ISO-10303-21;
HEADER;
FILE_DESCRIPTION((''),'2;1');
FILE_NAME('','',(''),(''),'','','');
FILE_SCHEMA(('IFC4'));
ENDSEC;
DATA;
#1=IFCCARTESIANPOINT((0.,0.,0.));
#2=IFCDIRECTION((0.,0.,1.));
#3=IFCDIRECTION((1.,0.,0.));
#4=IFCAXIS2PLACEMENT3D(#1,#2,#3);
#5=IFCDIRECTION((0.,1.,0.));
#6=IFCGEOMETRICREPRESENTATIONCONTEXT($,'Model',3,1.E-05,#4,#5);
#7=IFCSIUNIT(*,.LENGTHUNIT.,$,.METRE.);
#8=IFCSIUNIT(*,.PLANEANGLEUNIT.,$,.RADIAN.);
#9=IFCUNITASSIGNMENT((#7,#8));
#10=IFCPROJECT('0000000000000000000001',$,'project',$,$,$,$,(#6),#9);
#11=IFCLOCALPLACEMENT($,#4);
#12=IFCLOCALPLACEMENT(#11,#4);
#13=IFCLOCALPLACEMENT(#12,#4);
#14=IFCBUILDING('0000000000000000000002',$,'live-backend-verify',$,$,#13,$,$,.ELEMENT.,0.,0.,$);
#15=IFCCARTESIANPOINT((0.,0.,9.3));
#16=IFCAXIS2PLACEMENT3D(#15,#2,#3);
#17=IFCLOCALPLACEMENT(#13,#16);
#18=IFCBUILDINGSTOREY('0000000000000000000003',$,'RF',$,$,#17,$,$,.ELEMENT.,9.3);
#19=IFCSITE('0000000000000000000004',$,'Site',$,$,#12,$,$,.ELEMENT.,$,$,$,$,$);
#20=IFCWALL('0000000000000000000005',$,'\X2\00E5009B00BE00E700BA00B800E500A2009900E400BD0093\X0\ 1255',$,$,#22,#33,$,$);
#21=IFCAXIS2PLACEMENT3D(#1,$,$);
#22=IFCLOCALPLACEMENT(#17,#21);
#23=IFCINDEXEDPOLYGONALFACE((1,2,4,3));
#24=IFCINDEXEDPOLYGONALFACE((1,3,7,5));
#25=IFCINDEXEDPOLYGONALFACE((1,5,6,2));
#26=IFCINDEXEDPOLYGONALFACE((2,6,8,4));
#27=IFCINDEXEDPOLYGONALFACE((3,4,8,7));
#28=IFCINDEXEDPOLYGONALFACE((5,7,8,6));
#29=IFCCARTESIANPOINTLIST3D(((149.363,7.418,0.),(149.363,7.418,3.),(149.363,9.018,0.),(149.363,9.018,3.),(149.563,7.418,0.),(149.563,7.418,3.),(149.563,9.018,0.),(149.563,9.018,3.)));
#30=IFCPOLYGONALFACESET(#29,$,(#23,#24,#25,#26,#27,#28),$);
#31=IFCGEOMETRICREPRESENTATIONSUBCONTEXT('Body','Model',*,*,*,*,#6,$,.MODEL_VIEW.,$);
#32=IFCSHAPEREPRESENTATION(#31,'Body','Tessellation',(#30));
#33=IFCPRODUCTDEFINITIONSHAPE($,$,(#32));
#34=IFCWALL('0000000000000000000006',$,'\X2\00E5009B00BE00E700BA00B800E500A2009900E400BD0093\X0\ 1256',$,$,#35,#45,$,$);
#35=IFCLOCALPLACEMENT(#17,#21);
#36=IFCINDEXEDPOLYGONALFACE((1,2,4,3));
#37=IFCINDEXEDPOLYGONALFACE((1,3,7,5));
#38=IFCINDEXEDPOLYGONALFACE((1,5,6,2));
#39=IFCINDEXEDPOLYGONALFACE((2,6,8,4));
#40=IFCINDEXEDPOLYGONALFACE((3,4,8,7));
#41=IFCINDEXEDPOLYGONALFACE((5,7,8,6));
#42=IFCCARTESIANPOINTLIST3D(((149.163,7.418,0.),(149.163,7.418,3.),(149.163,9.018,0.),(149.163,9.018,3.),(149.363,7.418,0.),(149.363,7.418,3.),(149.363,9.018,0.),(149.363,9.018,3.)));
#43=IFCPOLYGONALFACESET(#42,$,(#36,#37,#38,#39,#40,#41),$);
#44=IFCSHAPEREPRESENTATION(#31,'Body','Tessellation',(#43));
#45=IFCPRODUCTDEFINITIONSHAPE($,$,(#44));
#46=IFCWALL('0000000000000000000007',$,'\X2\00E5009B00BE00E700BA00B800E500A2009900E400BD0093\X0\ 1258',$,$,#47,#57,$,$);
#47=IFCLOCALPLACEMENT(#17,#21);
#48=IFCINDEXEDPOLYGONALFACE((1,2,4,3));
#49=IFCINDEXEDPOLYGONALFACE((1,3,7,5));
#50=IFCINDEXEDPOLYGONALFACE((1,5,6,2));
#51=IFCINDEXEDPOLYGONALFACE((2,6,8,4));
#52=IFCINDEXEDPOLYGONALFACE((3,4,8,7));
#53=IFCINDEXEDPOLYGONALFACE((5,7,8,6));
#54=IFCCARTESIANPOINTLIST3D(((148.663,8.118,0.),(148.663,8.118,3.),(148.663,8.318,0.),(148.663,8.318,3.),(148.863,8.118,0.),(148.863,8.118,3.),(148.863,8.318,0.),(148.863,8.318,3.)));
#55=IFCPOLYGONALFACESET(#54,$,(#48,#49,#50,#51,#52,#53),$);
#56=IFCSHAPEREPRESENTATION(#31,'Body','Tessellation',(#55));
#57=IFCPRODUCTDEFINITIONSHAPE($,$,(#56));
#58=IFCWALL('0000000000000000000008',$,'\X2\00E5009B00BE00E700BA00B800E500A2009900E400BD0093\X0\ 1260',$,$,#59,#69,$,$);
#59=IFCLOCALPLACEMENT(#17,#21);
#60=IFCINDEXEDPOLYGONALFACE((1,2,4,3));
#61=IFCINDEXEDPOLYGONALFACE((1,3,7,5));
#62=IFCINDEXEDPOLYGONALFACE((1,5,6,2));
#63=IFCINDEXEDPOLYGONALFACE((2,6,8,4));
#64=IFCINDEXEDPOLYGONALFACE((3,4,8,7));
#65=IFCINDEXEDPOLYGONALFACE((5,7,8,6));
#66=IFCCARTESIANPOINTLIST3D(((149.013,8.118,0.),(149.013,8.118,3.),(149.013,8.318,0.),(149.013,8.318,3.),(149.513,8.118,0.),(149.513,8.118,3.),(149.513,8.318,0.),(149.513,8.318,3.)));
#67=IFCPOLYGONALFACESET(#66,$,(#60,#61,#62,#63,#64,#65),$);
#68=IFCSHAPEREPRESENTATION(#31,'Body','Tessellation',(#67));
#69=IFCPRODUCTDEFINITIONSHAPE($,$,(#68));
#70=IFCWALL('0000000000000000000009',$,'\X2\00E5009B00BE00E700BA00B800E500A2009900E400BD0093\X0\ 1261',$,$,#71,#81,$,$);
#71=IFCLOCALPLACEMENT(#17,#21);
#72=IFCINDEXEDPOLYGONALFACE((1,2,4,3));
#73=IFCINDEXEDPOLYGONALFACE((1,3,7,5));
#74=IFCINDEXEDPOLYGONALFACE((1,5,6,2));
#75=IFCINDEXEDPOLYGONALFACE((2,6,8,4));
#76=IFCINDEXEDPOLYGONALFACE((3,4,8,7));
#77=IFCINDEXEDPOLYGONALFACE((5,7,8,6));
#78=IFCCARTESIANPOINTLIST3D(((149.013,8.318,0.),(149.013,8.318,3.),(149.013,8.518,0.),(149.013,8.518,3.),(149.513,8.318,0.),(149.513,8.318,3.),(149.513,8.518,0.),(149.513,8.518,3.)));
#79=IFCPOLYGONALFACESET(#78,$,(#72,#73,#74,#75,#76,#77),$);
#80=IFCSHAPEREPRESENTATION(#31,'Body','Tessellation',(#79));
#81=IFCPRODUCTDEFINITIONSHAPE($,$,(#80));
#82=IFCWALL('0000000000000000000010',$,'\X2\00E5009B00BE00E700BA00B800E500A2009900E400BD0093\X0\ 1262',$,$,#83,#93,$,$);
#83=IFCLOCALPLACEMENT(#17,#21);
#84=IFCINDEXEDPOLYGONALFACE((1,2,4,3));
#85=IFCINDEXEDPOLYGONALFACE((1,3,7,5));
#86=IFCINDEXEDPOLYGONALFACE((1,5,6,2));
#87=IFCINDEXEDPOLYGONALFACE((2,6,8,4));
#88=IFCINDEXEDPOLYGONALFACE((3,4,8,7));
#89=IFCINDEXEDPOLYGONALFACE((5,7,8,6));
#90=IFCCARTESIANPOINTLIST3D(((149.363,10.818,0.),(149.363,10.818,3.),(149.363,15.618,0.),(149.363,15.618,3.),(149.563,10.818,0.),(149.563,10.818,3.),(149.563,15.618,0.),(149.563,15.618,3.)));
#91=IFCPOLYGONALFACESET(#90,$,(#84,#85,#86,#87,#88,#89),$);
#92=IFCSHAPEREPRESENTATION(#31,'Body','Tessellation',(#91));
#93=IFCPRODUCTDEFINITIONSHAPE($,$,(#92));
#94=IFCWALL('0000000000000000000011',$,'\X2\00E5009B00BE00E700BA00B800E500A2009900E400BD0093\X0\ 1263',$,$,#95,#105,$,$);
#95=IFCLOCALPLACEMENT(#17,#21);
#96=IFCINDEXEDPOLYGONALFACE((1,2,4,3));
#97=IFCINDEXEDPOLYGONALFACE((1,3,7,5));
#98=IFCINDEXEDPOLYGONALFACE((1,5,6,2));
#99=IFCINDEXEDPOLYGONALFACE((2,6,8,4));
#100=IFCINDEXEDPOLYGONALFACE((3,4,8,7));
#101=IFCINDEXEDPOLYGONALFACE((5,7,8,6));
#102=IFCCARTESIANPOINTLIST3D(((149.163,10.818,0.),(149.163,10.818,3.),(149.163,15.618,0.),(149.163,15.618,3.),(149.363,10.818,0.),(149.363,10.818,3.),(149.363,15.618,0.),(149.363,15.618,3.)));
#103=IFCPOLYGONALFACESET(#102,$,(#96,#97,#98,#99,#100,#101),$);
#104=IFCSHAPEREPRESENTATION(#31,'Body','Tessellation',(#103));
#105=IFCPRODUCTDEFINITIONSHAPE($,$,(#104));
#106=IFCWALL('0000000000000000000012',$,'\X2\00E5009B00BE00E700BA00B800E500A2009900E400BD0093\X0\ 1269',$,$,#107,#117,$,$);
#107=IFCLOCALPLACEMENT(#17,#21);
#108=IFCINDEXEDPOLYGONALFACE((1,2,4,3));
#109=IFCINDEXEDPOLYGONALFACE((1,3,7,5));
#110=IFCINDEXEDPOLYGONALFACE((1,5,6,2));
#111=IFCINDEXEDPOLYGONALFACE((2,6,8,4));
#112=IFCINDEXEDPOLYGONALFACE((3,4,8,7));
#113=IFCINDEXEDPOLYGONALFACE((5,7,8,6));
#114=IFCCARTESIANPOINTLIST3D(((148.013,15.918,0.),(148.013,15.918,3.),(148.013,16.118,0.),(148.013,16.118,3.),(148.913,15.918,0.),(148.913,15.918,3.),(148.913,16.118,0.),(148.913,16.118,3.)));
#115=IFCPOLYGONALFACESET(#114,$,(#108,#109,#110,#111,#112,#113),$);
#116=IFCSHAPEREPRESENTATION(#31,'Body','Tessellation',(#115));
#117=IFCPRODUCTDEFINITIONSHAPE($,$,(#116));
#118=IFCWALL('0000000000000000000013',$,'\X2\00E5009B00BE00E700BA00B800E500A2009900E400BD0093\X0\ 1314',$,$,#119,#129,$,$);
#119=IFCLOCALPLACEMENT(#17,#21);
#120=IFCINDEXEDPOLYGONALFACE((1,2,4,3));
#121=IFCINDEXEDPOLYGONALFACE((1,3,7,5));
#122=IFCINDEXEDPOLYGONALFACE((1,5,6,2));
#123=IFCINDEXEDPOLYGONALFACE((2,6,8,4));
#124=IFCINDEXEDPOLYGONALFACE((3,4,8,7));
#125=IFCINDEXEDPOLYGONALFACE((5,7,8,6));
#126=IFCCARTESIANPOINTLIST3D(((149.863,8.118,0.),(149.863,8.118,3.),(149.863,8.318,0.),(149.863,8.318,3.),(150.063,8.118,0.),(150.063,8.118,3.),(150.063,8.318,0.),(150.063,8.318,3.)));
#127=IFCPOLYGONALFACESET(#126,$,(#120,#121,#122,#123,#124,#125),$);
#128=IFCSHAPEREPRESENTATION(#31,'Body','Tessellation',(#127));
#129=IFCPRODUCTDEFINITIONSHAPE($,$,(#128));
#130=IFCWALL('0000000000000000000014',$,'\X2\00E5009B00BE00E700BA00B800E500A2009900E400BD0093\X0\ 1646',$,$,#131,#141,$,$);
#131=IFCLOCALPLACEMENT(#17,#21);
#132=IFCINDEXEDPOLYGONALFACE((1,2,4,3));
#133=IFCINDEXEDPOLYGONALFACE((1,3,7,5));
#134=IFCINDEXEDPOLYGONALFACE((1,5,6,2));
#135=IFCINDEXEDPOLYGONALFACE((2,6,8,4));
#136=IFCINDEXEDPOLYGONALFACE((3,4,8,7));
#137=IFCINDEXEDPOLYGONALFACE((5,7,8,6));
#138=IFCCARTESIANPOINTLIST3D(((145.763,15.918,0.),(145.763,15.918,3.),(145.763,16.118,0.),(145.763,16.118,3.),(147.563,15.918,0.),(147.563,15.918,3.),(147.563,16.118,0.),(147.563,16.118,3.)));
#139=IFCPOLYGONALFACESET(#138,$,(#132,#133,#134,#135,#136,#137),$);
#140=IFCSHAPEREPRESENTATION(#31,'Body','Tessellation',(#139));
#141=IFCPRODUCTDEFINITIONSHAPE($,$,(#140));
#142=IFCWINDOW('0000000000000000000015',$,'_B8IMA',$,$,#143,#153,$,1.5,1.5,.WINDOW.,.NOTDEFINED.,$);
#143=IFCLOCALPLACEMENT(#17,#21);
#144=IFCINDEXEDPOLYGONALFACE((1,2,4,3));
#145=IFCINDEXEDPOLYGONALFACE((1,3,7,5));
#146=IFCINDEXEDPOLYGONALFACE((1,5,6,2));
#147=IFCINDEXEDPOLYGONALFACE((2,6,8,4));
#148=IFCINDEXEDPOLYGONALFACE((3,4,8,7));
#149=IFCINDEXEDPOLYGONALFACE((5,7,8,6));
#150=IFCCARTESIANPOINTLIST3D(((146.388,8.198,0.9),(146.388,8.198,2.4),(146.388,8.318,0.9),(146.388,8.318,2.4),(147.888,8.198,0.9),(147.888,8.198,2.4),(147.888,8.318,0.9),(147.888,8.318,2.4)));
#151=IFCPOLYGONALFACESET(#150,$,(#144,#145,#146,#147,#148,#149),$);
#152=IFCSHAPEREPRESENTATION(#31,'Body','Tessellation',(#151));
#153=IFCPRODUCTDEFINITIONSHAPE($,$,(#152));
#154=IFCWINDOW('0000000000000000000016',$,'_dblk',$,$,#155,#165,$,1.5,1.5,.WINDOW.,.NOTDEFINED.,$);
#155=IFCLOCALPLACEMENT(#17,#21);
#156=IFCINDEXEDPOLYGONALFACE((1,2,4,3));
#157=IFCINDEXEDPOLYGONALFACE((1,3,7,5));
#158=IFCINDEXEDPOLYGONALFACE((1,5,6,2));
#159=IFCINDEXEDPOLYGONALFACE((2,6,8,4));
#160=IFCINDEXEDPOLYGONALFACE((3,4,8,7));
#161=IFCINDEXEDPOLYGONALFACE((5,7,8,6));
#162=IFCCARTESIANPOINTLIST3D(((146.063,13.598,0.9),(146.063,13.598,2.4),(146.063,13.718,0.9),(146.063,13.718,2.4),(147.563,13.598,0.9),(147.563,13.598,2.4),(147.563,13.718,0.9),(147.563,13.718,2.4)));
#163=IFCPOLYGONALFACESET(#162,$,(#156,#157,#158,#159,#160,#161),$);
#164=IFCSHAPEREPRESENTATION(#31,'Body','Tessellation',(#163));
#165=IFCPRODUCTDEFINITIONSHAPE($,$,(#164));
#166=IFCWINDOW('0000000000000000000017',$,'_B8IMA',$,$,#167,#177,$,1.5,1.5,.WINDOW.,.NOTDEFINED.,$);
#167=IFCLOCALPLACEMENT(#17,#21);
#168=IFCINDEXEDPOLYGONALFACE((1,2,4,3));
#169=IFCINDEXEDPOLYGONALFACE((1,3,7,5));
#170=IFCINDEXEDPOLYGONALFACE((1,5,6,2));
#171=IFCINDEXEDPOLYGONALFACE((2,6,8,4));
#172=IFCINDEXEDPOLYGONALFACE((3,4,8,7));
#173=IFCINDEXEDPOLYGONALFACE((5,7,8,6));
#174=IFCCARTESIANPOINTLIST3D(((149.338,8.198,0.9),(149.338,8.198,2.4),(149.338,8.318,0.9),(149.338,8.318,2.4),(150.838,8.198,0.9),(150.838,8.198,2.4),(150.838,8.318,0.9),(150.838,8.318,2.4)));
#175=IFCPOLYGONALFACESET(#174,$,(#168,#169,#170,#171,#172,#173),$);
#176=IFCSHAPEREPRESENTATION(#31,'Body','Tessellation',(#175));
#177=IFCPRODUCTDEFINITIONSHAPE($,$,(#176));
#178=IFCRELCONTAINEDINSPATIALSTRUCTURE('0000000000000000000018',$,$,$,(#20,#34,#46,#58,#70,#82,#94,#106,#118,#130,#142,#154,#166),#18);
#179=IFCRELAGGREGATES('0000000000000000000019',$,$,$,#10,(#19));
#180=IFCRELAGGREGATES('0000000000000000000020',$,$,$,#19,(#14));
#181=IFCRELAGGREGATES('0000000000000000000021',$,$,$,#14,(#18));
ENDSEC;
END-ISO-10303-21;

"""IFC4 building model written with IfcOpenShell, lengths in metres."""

from ifc_helpers import new_model, si_unit, direction, frame, frame_2d, origin_with_axes, place, context, subcontext, project, spatial, rectangle, extrude, element, save


model = new_model("IFC4")

# Units and contexts
model_context = context("Model", 3, precision=1e-05, world=origin_with_axes(), true_north=direction((0.0, 1.0, 0.0)))
body_context = subcontext(model_context, "Body", "Model", "MODEL_VIEW")
ifc_project = project(units=[si_unit("LENGTHUNIT", "METRE"), si_unit("PLANEANGLEUNIT", "RADIAN")], contexts=[model_context])

# Site, building, storey
placement = place(None, origin_with_axes())
site_placement = place(placement, origin_with_axes())
site = spatial("IfcSite", under=ifc_project, at=site_placement, Name="Site", CompositionType="ELEMENT")
building_placement = place(site_placement, origin_with_axes())
building = spatial("IfcBuilding", under=site, at=building_placement, Name="live-backend-verify", CompositionType="ELEMENT", ElevationOfRefHeight=0.0, ElevationOfTerrain=0.0)
storey_placement = place(building_placement, frame((0.0, 0.0, 9.3), z_axis=(0.0, 0.0, 1.0), x_axis=(1.0, 0.0, 0.0)))
storey = spatial("IfcBuildingStorey", under=building, at=storey_placement, Name="RF", CompositionType="ELEMENT", Elevation=9.3)

# Walls
for number, where, z_axis, x_axis, name in (
    (1, (149.463, 8.218, 0.0), (0.0, 0.0, 1.0), (0.0, -1.0, 0.0), "å\u009b¾çº¸å¢\u0099ä½\u0093 1255"),
    (2, (149.263, 8.218, 0.0), (0.0, 0.0, 1.0), (0.0, -1.0, 0.0), "å\u009b¾çº¸å¢\u0099ä½\u0093 1256"),
):
    element("IfcWall", number, at=place(storey_placement, frame(where, z_axis=z_axis, x_axis=x_axis)), inside=storey, Name=name, context=body_context, shape_type="SweptSolid", body=[
        extrude(rectangle(XDim=1.6, YDim=0.2, at=frame_2d((0.0, 0.0), x_axis=(1.0, 0.0, 0.0))), frame((0.0, 0.0, 0.0), z_axis=(0.0, 0.0, 1.0)), (0.0, 0.0, 1.0), 3.0),
    ])
wall_1_placement = place(storey_placement, frame((148.763, 8.218, 0.0), z_axis=(0.0, 0.0, 1.0), x_axis=(0.0, 1.0, 0.0)))
element("IfcWall", 3, at=wall_1_placement, inside=storey, Name="å\u009b¾çº¸å¢\u0099ä½\u0093 1258", context=body_context, shape_type="SweptSolid", body=[
    extrude(rectangle(XDim=0.2, YDim=0.2, at=frame_2d((0.0, 0.0), x_axis=(1.0, 0.0, 0.0))), frame((0.0, 0.0, 0.0), z_axis=(0.0, 0.0, 1.0)), (0.0, 0.0, 1.0), 3.0),
])
for number, where, z_axis, x_axis, name in (
    (4, (149.263, 8.218, 0.0), (0.0, 0.0, 1.0), (-1.0, 0.0, 0.0), "å\u009b¾çº¸å¢\u0099ä½\u0093 1260"),
    (5, (149.263, 8.418, 0.0), (0.0, 0.0, 1.0), (-1.0, 0.0, 0.0), "å\u009b¾çº¸å¢\u0099ä½\u0093 1261"),
):
    element("IfcWall", number, at=place(storey_placement, frame(where, z_axis=z_axis, x_axis=x_axis)), inside=storey, Name=name, context=body_context, shape_type="SweptSolid", body=[
        extrude(rectangle(XDim=0.5, YDim=0.2, at=frame_2d((0.0, 0.0), x_axis=(1.0, 0.0, 0.0))), frame((0.0, 0.0, 0.0), z_axis=(0.0, 0.0, 1.0)), (0.0, 0.0, 1.0), 3.0),
    ])
for number, where, z_axis, x_axis, name in (
    (6, (149.463, 13.218, 0.0), (0.0, 0.0, 1.0), (0.0, -1.0, 0.0), "å\u009b¾çº¸å¢\u0099ä½\u0093 1262"),
    (7, (149.263, 13.218, 0.0), (0.0, 0.0, 1.0), (0.0, -1.0, 0.0), "å\u009b¾çº¸å¢\u0099ä½\u0093 1263"),
):
    element("IfcWall", number, at=place(storey_placement, frame(where, z_axis=z_axis, x_axis=x_axis)), inside=storey, Name=name, context=body_context, shape_type="SweptSolid", body=[
        extrude(rectangle(XDim=4.8, YDim=0.2, at=frame_2d((0.0, 0.0), x_axis=(1.0, 0.0, 0.0))), frame((0.0, 0.0, 0.0), z_axis=(0.0, 0.0, 1.0)), (0.0, 0.0, 1.0), 3.0),
    ])
wall_2_placement = place(storey_placement, frame((148.463, 16.018, 0.0), z_axis=(0.0, 0.0, 1.0), x_axis=(1.0, 0.0, 0.0)))
element("IfcWall", 8, at=wall_2_placement, inside=storey, Name="å\u009b¾çº¸å¢\u0099ä½\u0093 1269", context=body_context, shape_type="SweptSolid", body=[
    extrude(rectangle(XDim=0.9, YDim=0.2, at=frame_2d((0.0, 0.0), x_axis=(1.0, 0.0, 0.0))), frame((0.0, 0.0, 0.0), z_axis=(0.0, 0.0, 1.0)), (0.0, 0.0, 1.0), 3.0),
])
wall_3_placement = place(storey_placement, frame((149.963, 8.218, 0.0), z_axis=(0.0, 0.0, 1.0), x_axis=(0.0, 1.0, 0.0)))
element("IfcWall", 9, at=wall_3_placement, inside=storey, Name="å\u009b¾çº¸å¢\u0099ä½\u0093 1314", context=body_context, shape_type="SweptSolid", body=[
    extrude(rectangle(XDim=0.2, YDim=0.2, at=frame_2d((0.0, 0.0), x_axis=(1.0, 0.0, 0.0))), frame((0.0, 0.0, 0.0), z_axis=(0.0, 0.0, 1.0)), (0.0, 0.0, 1.0), 3.0),
])
wall_4_placement = place(storey_placement, frame((146.663, 16.018, 0.0), z_axis=(0.0, 0.0, 1.0), x_axis=(1.0, 0.0, 0.0)))
element("IfcWall", 10, at=wall_4_placement, inside=storey, Name="å\u009b¾çº¸å¢\u0099ä½\u0093 1646", context=body_context, shape_type="SweptSolid", body=[
    extrude(rectangle(XDim=1.8, YDim=0.2, at=frame_2d((0.0, 0.0), x_axis=(1.0, 0.0, 0.0))), frame((0.0, 0.0, 0.0), z_axis=(0.0, 0.0, 1.0)), (0.0, 0.0, 1.0), 3.0),
])

# Windows
for number, where, z_axis, x_axis, name in (
    (11, (147.138, 8.258, 0.9), (0.0, 0.0, 1.0), (1.0, 0.0, 0.0), "_B8IMA"),
    (12, (146.813, 13.658, 0.9), (0.0, 0.0, 1.0), (1.0, 0.0, 0.0), "_dblk"),
    (13, (150.088, 8.258, 0.9), (0.0, 0.0, 1.0), (1.0, 0.0, 0.0), "_B8IMA"),
):
    element("IfcWindow", number, at=place(storey_placement, frame(where, z_axis=z_axis, x_axis=x_axis)), inside=storey, Name=name, OverallHeight=1.5, OverallWidth=1.5, PartitioningType="NOTDEFINED", PredefinedType="WINDOW", context=body_context, shape_type="SweptSolid", body=[
        extrude(rectangle(XDim=1.5, YDim=0.12, at=frame_2d((0.0, 0.0), x_axis=(1.0, 0.0, 0.0))), frame((0.0, 0.0, 0.0), z_axis=(0.0, 0.0, 1.0)), (0.0, 0.0, 1.0), 1.5),
    ])

save(model, "model.ifc")
